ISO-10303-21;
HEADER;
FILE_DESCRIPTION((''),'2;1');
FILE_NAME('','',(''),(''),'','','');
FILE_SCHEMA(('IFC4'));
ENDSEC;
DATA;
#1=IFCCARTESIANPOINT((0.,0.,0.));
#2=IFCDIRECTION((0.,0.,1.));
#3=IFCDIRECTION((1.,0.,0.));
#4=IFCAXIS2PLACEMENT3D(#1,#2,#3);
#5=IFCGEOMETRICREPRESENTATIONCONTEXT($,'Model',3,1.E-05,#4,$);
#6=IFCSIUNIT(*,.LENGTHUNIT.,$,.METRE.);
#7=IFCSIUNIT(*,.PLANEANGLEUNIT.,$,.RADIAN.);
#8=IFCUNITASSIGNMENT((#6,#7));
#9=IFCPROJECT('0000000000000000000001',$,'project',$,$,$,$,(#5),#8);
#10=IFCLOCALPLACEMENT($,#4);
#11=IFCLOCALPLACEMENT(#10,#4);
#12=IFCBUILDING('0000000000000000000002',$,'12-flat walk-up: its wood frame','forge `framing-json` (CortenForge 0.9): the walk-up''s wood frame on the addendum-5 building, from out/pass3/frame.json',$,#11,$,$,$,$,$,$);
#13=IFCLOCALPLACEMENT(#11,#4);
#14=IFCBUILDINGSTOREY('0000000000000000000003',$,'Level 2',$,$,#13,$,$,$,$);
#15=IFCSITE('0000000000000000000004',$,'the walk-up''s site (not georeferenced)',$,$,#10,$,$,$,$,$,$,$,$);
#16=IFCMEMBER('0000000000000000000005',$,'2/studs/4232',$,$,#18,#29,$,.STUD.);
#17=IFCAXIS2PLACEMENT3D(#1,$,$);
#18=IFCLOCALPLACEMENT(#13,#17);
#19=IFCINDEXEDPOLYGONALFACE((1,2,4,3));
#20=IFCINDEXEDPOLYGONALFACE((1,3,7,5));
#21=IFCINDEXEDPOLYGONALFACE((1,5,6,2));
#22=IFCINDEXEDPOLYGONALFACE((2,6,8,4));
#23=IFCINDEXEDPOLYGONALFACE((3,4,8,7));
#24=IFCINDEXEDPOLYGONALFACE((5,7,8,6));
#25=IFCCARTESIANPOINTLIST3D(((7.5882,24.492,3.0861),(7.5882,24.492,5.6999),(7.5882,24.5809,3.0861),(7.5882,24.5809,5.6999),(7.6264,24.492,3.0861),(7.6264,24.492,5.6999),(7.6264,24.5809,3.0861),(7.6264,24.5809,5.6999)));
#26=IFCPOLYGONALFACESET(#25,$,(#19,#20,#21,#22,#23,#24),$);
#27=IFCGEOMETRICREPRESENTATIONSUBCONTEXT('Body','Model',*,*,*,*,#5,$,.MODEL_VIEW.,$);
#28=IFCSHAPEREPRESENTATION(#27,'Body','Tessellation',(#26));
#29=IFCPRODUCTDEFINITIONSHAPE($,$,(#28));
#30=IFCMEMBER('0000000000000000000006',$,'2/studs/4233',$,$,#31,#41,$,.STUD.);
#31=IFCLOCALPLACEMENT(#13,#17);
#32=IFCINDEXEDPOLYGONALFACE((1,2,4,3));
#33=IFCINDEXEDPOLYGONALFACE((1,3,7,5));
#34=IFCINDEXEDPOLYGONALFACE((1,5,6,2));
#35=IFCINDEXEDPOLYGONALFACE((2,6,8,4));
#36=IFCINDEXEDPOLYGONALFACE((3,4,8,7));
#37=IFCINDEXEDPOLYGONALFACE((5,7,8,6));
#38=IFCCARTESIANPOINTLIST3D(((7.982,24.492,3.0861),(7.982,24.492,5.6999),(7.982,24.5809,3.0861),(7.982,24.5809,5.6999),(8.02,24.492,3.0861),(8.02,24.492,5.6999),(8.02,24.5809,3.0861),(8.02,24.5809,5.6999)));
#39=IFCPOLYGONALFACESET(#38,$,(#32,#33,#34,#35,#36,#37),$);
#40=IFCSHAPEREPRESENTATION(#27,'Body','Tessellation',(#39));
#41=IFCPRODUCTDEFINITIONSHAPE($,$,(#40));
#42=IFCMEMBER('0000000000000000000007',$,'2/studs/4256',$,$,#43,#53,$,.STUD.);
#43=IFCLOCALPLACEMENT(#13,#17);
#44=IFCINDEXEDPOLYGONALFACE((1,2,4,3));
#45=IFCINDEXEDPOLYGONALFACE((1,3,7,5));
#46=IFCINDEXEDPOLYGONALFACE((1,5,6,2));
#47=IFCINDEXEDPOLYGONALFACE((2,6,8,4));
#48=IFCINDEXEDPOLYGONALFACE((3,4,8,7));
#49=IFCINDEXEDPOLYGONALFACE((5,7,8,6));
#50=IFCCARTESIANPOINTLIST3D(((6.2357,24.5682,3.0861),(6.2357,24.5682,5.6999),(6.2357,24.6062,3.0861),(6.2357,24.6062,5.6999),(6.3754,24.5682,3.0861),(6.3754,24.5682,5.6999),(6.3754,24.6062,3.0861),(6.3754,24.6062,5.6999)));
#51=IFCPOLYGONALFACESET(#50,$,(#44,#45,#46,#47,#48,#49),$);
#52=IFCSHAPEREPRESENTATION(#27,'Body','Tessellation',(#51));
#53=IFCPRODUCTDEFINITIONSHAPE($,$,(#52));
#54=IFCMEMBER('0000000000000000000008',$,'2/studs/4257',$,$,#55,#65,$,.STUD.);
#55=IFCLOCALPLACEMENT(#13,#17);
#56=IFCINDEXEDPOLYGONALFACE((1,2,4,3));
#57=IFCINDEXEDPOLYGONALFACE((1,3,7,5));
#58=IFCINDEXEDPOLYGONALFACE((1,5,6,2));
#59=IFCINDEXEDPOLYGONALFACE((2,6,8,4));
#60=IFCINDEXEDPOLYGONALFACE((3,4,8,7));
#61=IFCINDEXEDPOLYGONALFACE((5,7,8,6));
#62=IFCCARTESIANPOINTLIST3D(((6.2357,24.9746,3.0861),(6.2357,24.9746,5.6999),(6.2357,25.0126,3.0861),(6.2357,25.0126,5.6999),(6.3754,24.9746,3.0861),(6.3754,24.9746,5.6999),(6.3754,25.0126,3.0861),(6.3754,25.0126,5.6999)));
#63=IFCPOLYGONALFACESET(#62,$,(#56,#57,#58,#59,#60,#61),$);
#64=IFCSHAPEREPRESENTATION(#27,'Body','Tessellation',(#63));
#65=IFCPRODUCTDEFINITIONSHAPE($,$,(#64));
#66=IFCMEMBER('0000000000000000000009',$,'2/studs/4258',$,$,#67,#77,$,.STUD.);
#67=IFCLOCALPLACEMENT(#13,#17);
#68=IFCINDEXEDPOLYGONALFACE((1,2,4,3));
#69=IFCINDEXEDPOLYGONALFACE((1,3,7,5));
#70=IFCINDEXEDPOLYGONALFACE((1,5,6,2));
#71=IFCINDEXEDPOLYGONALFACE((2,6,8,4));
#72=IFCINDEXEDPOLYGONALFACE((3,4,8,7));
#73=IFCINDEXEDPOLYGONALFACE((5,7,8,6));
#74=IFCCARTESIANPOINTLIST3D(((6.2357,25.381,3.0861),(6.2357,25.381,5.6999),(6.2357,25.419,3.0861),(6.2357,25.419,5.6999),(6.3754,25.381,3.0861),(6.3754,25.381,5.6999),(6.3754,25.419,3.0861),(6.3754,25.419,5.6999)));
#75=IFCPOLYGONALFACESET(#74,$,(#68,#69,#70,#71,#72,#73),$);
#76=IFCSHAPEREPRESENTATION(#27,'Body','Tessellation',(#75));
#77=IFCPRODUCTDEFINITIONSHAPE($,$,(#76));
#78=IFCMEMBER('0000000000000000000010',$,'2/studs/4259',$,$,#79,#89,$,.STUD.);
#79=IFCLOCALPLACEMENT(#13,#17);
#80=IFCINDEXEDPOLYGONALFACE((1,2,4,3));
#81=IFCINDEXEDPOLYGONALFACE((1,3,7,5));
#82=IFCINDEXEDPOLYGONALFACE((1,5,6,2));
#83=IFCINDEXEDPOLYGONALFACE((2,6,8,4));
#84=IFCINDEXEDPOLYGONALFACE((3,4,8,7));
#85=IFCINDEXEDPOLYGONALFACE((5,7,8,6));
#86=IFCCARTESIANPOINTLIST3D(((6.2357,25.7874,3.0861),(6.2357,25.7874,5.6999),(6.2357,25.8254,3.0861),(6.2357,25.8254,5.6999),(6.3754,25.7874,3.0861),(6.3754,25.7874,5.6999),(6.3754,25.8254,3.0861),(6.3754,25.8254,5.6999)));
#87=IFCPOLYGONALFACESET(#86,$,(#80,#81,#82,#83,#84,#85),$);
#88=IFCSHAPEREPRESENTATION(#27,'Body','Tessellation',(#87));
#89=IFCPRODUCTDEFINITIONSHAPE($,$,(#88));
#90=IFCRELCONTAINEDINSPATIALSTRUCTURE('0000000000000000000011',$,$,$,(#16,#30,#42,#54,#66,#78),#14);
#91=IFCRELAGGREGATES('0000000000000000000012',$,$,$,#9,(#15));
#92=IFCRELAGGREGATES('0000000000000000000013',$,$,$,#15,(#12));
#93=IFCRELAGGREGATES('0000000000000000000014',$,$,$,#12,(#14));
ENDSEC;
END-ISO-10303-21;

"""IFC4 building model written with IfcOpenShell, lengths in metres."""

from ifc_helpers import new_model, si_unit, frame, frame_2d, origin, origin_with_axes, place, context, subcontext, project, spatial, rectangle, extrude, element, save


model = new_model("IFC4")

# Units and contexts
model_context = context("Model", 3, precision=1e-05, world=origin_with_axes())
body_context = subcontext(model_context, "Body", "Model", "MODEL_VIEW")
ifc_project = project(units=[si_unit("LENGTHUNIT", "METRE"), si_unit("PLANEANGLEUNIT", "RADIAN")], contexts=[model_context])

# Site, building, storey
site_placement = place(None, origin_with_axes())
site = spatial("IfcSite", under=ifc_project, at=site_placement, Name="the walk-up's site (not georeferenced)")
building_placement = place(site_placement, origin_with_axes())
building = spatial("IfcBuilding", under=site, at=building_placement, Name="12-flat walk-up: its wood frame", Description="forge `framing-json` (CortenForge 0.9): the walk-up's wood frame on the addendum-5 building, from out/pass3/frame.json")
storey_placement = place(building_placement, origin_with_axes())
storey = spatial("IfcBuildingStorey", under=building, at=storey_placement, Name="Level 2")

# Members
for number, where, z_axis, x_axis, name in (
    (1, (7.5883, 24.4919, 3.0861), (0.0, 0.0, 1.0), (1.0, 0.0, 0.0), "2/studs/4232"),
):
    element("IfcMember", number, at=place(storey_placement, frame(where, z_axis=z_axis, x_axis=x_axis)), inside=storey, Name=name, PredefinedType="STUD", context=body_context, shape_type="SweptSolid", body=[
        extrude(rectangle(XDim=0.0381, YDim=0.0889, at=frame_2d((0.0191, 0.0445))), origin(), (0.0, 0.0, 1.0), 2.6138),
    ])
member_1_placement = place(storey_placement, frame((7.982, 24.4919, 3.0861), z_axis=(0.0, 0.0, 1.0), x_axis=(1.0, 0.0, 0.0)))
element("IfcMember", 2, at=member_1_placement, inside=storey, Name="2/studs/4233", PredefinedType="STUD", context=body_context, shape_type="SweptSolid", body=[
    extrude(rectangle(XDim=0.0381, YDim=0.0889, at=frame_2d((0.019, 0.0445))), origin(), (0.0, 0.0, 1.0), 2.6138),
])
for number, where, z_axis, x_axis, name in (
    (3, (6.2357, 24.5681, 3.0861), (0.0, 0.0, 1.0), (1.0, 0.0, 0.0), "2/studs/4256"),
    (4, (6.2357, 24.9746, 3.0861), (0.0, 0.0, 1.0), (1.0, 0.0, 0.0), "2/studs/4257"),
    (5, (6.2357, 25.3809, 3.0861), (0.0, 0.0, 1.0), (1.0, 0.0, 0.0), "2/studs/4258"),
    (6, (6.2357, 25.7873, 3.0861), (0.0, 0.0, 1.0), (1.0, 0.0, 0.0), "2/studs/4259"),
):
    element("IfcMember", number, at=place(storey_placement, frame(where, z_axis=z_axis, x_axis=x_axis)), inside=storey, Name=name, PredefinedType="STUD", context=body_context, shape_type="SweptSolid", body=[
        extrude(rectangle(XDim=0.1397, YDim=0.0381, at=frame_2d((0.0699, 0.0191))), origin(), (0.0, 0.0, 1.0), 2.6138),
    ])

save(model, "model.ifc")
